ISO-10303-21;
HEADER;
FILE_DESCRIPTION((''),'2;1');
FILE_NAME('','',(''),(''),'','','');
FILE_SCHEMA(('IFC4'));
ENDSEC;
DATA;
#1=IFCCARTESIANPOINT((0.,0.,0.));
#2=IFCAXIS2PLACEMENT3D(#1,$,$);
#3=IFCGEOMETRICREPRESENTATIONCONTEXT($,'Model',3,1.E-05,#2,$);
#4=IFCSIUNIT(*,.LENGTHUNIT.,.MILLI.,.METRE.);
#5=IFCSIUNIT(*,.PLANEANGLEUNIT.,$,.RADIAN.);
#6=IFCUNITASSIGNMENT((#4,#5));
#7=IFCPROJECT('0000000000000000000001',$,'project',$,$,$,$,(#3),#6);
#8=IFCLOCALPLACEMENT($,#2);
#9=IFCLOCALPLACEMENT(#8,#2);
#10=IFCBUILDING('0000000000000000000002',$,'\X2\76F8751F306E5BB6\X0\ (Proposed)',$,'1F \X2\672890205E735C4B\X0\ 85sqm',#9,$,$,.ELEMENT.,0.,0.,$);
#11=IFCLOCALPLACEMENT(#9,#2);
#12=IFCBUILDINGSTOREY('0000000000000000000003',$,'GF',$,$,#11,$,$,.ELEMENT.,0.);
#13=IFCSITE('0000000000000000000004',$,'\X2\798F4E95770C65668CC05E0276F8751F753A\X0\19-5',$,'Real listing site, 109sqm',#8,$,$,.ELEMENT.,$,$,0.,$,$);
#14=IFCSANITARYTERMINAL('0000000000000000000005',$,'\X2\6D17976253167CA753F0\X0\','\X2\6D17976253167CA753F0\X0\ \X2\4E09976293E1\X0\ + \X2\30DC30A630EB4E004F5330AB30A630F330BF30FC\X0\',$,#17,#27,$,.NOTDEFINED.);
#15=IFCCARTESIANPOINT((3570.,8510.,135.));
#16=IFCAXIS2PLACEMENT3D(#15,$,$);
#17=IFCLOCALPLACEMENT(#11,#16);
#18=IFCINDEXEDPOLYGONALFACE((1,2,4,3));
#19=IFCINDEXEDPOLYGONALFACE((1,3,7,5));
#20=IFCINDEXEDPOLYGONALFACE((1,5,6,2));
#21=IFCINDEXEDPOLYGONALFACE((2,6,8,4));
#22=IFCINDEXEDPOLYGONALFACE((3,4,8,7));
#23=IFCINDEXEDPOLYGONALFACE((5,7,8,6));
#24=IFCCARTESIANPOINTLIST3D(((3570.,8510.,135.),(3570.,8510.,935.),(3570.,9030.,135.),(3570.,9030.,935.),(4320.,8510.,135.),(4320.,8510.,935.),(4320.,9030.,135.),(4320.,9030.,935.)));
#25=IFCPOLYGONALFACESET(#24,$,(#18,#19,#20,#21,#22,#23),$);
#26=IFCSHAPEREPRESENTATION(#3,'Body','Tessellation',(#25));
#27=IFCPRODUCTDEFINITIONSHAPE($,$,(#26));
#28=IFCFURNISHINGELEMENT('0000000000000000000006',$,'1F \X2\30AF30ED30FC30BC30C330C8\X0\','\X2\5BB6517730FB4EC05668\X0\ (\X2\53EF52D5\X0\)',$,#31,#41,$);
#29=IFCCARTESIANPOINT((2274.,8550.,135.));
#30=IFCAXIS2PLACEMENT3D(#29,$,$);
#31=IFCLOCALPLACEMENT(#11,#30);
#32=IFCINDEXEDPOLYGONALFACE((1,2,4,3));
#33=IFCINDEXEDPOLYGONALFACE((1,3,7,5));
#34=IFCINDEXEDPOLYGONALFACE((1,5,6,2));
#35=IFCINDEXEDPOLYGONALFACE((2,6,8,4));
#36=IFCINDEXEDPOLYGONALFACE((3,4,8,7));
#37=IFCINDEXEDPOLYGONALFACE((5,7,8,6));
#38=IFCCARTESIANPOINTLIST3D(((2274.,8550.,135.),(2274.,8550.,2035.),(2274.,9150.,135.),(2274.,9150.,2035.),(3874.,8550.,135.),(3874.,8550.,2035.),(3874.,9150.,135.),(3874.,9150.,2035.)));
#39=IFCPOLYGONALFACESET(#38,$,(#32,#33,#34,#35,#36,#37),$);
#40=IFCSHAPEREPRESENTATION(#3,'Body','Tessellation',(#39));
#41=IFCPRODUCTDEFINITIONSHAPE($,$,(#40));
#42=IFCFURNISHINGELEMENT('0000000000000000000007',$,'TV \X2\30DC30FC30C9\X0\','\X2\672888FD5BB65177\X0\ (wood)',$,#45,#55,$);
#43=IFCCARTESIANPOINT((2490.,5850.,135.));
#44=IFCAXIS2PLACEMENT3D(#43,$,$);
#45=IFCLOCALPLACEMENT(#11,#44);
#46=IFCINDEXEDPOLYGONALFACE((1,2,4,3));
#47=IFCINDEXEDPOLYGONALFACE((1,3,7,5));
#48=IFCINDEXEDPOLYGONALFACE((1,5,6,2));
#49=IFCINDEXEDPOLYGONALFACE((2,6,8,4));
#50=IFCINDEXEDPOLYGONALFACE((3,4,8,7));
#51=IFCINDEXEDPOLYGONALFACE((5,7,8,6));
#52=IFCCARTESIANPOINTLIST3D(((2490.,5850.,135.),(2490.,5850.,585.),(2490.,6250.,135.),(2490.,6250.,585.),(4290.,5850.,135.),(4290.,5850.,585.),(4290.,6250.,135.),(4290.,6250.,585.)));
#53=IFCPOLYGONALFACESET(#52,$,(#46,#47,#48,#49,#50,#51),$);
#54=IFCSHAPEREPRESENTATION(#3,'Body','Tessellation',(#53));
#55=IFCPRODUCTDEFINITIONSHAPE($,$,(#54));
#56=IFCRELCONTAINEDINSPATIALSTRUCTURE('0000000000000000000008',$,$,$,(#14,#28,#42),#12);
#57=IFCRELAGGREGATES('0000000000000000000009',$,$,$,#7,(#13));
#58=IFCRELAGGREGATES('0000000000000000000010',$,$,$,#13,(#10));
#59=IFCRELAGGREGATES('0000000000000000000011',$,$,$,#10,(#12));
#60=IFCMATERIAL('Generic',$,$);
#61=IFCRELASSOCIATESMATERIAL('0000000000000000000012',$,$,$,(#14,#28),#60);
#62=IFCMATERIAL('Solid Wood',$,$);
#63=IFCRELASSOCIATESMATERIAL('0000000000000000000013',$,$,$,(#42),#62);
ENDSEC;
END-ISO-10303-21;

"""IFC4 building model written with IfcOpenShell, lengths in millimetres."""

from ifc_helpers import new_model, si_unit, frame, frame_2d, origin, place, context, project, spatial, rectangle, extrude, material, element, save


model = new_model("IFC4")

# Units and contexts
model_context = context("Model", 3, precision=1e-05, world=origin())
ifc_project = project(units=[si_unit("LENGTHUNIT", "METRE", prefix="MILLI"), si_unit("PLANEANGLEUNIT", "RADIAN")], contexts=[model_context])

# Site, building, storey
site_placement = place(None, origin())
site = spatial("IfcSite", under=ifc_project, at=site_placement, Name="福井県敦賀市相生町19-5", ObjectType="Real listing site, 109sqm", CompositionType="ELEMENT", RefElevation=0.0)
building_placement = place(site_placement, origin())
building = spatial("IfcBuilding", under=site, at=building_placement, Name="相生の家 (Proposed)", ObjectType="1F 木造平屋 85sqm", CompositionType="ELEMENT", ElevationOfRefHeight=0.0, ElevationOfTerrain=0.0)
storey_placement = place(building_placement, origin())
storey = spatial("IfcBuildingStorey", under=building, at=storey_placement, Name="GF", CompositionType="ELEMENT", Elevation=0.0)

# Shared definitions
ifc_material_1 = material(Name="Solid Wood")

# Shared definitions
ifc_material_2 = material(Name="Generic")

# Sanitary terminal
sanitary_terminal_1_placement = place(storey_placement, frame((3570.0, 8510.0, 135.0)))
element("IfcSanitaryTerminal", 1, at=sanitary_terminal_1_placement, inside=storey, material=ifc_material_2, Name="洗面化粧台", Description="洗面化粧台 三面鏡 + ボウル一体カウンター", PredefinedType="NOTDEFINED", context=model_context, shape_type="SweptSolid", body=[
    extrude(rectangle(XDim=750.0, YDim=520.0, at=frame_2d((375.0, 260.0))), frame((3570.0, 8510.0, 135.0)), (0.0, 0.0, 1.0), 800.0),
])

# Furnishing elements
furnishing_1_placement = place(storey_placement, frame((2274.0, 8550.0, 135.0)))
element("IfcFurnishingElement", 2, at=furnishing_1_placement, inside=storey, material=ifc_material_2, Name="1F クローゼット", Description="家具・什器 (可動)", context=model_context, shape_type="SweptSolid", body=[
    extrude(rectangle(XDim=1600.0, YDim=600.0, at=frame_2d((800.0, 300.0))), frame((2274.0, 8550.0, 135.0)), (0.0, 0.0, 1.0), 1900.0),
])
furnishing_2_placement = place(storey_placement, frame((2490.0, 5850.0, 135.0)))
element("IfcFurnishingElement", 3, at=furnishing_2_placement, inside=storey, material=ifc_material_1, Name="TV ボード", Description="木製家具 (wood)", context=model_context, shape_type="SweptSolid", body=[
    extrude(rectangle(XDim=1800.0, YDim=400.0, at=frame_2d((900.0, 200.0))), frame((2490.0, 5850.0, 135.0)), (0.0, 0.0, 1.0), 450.0),
])

save(model, "model.ifc")
